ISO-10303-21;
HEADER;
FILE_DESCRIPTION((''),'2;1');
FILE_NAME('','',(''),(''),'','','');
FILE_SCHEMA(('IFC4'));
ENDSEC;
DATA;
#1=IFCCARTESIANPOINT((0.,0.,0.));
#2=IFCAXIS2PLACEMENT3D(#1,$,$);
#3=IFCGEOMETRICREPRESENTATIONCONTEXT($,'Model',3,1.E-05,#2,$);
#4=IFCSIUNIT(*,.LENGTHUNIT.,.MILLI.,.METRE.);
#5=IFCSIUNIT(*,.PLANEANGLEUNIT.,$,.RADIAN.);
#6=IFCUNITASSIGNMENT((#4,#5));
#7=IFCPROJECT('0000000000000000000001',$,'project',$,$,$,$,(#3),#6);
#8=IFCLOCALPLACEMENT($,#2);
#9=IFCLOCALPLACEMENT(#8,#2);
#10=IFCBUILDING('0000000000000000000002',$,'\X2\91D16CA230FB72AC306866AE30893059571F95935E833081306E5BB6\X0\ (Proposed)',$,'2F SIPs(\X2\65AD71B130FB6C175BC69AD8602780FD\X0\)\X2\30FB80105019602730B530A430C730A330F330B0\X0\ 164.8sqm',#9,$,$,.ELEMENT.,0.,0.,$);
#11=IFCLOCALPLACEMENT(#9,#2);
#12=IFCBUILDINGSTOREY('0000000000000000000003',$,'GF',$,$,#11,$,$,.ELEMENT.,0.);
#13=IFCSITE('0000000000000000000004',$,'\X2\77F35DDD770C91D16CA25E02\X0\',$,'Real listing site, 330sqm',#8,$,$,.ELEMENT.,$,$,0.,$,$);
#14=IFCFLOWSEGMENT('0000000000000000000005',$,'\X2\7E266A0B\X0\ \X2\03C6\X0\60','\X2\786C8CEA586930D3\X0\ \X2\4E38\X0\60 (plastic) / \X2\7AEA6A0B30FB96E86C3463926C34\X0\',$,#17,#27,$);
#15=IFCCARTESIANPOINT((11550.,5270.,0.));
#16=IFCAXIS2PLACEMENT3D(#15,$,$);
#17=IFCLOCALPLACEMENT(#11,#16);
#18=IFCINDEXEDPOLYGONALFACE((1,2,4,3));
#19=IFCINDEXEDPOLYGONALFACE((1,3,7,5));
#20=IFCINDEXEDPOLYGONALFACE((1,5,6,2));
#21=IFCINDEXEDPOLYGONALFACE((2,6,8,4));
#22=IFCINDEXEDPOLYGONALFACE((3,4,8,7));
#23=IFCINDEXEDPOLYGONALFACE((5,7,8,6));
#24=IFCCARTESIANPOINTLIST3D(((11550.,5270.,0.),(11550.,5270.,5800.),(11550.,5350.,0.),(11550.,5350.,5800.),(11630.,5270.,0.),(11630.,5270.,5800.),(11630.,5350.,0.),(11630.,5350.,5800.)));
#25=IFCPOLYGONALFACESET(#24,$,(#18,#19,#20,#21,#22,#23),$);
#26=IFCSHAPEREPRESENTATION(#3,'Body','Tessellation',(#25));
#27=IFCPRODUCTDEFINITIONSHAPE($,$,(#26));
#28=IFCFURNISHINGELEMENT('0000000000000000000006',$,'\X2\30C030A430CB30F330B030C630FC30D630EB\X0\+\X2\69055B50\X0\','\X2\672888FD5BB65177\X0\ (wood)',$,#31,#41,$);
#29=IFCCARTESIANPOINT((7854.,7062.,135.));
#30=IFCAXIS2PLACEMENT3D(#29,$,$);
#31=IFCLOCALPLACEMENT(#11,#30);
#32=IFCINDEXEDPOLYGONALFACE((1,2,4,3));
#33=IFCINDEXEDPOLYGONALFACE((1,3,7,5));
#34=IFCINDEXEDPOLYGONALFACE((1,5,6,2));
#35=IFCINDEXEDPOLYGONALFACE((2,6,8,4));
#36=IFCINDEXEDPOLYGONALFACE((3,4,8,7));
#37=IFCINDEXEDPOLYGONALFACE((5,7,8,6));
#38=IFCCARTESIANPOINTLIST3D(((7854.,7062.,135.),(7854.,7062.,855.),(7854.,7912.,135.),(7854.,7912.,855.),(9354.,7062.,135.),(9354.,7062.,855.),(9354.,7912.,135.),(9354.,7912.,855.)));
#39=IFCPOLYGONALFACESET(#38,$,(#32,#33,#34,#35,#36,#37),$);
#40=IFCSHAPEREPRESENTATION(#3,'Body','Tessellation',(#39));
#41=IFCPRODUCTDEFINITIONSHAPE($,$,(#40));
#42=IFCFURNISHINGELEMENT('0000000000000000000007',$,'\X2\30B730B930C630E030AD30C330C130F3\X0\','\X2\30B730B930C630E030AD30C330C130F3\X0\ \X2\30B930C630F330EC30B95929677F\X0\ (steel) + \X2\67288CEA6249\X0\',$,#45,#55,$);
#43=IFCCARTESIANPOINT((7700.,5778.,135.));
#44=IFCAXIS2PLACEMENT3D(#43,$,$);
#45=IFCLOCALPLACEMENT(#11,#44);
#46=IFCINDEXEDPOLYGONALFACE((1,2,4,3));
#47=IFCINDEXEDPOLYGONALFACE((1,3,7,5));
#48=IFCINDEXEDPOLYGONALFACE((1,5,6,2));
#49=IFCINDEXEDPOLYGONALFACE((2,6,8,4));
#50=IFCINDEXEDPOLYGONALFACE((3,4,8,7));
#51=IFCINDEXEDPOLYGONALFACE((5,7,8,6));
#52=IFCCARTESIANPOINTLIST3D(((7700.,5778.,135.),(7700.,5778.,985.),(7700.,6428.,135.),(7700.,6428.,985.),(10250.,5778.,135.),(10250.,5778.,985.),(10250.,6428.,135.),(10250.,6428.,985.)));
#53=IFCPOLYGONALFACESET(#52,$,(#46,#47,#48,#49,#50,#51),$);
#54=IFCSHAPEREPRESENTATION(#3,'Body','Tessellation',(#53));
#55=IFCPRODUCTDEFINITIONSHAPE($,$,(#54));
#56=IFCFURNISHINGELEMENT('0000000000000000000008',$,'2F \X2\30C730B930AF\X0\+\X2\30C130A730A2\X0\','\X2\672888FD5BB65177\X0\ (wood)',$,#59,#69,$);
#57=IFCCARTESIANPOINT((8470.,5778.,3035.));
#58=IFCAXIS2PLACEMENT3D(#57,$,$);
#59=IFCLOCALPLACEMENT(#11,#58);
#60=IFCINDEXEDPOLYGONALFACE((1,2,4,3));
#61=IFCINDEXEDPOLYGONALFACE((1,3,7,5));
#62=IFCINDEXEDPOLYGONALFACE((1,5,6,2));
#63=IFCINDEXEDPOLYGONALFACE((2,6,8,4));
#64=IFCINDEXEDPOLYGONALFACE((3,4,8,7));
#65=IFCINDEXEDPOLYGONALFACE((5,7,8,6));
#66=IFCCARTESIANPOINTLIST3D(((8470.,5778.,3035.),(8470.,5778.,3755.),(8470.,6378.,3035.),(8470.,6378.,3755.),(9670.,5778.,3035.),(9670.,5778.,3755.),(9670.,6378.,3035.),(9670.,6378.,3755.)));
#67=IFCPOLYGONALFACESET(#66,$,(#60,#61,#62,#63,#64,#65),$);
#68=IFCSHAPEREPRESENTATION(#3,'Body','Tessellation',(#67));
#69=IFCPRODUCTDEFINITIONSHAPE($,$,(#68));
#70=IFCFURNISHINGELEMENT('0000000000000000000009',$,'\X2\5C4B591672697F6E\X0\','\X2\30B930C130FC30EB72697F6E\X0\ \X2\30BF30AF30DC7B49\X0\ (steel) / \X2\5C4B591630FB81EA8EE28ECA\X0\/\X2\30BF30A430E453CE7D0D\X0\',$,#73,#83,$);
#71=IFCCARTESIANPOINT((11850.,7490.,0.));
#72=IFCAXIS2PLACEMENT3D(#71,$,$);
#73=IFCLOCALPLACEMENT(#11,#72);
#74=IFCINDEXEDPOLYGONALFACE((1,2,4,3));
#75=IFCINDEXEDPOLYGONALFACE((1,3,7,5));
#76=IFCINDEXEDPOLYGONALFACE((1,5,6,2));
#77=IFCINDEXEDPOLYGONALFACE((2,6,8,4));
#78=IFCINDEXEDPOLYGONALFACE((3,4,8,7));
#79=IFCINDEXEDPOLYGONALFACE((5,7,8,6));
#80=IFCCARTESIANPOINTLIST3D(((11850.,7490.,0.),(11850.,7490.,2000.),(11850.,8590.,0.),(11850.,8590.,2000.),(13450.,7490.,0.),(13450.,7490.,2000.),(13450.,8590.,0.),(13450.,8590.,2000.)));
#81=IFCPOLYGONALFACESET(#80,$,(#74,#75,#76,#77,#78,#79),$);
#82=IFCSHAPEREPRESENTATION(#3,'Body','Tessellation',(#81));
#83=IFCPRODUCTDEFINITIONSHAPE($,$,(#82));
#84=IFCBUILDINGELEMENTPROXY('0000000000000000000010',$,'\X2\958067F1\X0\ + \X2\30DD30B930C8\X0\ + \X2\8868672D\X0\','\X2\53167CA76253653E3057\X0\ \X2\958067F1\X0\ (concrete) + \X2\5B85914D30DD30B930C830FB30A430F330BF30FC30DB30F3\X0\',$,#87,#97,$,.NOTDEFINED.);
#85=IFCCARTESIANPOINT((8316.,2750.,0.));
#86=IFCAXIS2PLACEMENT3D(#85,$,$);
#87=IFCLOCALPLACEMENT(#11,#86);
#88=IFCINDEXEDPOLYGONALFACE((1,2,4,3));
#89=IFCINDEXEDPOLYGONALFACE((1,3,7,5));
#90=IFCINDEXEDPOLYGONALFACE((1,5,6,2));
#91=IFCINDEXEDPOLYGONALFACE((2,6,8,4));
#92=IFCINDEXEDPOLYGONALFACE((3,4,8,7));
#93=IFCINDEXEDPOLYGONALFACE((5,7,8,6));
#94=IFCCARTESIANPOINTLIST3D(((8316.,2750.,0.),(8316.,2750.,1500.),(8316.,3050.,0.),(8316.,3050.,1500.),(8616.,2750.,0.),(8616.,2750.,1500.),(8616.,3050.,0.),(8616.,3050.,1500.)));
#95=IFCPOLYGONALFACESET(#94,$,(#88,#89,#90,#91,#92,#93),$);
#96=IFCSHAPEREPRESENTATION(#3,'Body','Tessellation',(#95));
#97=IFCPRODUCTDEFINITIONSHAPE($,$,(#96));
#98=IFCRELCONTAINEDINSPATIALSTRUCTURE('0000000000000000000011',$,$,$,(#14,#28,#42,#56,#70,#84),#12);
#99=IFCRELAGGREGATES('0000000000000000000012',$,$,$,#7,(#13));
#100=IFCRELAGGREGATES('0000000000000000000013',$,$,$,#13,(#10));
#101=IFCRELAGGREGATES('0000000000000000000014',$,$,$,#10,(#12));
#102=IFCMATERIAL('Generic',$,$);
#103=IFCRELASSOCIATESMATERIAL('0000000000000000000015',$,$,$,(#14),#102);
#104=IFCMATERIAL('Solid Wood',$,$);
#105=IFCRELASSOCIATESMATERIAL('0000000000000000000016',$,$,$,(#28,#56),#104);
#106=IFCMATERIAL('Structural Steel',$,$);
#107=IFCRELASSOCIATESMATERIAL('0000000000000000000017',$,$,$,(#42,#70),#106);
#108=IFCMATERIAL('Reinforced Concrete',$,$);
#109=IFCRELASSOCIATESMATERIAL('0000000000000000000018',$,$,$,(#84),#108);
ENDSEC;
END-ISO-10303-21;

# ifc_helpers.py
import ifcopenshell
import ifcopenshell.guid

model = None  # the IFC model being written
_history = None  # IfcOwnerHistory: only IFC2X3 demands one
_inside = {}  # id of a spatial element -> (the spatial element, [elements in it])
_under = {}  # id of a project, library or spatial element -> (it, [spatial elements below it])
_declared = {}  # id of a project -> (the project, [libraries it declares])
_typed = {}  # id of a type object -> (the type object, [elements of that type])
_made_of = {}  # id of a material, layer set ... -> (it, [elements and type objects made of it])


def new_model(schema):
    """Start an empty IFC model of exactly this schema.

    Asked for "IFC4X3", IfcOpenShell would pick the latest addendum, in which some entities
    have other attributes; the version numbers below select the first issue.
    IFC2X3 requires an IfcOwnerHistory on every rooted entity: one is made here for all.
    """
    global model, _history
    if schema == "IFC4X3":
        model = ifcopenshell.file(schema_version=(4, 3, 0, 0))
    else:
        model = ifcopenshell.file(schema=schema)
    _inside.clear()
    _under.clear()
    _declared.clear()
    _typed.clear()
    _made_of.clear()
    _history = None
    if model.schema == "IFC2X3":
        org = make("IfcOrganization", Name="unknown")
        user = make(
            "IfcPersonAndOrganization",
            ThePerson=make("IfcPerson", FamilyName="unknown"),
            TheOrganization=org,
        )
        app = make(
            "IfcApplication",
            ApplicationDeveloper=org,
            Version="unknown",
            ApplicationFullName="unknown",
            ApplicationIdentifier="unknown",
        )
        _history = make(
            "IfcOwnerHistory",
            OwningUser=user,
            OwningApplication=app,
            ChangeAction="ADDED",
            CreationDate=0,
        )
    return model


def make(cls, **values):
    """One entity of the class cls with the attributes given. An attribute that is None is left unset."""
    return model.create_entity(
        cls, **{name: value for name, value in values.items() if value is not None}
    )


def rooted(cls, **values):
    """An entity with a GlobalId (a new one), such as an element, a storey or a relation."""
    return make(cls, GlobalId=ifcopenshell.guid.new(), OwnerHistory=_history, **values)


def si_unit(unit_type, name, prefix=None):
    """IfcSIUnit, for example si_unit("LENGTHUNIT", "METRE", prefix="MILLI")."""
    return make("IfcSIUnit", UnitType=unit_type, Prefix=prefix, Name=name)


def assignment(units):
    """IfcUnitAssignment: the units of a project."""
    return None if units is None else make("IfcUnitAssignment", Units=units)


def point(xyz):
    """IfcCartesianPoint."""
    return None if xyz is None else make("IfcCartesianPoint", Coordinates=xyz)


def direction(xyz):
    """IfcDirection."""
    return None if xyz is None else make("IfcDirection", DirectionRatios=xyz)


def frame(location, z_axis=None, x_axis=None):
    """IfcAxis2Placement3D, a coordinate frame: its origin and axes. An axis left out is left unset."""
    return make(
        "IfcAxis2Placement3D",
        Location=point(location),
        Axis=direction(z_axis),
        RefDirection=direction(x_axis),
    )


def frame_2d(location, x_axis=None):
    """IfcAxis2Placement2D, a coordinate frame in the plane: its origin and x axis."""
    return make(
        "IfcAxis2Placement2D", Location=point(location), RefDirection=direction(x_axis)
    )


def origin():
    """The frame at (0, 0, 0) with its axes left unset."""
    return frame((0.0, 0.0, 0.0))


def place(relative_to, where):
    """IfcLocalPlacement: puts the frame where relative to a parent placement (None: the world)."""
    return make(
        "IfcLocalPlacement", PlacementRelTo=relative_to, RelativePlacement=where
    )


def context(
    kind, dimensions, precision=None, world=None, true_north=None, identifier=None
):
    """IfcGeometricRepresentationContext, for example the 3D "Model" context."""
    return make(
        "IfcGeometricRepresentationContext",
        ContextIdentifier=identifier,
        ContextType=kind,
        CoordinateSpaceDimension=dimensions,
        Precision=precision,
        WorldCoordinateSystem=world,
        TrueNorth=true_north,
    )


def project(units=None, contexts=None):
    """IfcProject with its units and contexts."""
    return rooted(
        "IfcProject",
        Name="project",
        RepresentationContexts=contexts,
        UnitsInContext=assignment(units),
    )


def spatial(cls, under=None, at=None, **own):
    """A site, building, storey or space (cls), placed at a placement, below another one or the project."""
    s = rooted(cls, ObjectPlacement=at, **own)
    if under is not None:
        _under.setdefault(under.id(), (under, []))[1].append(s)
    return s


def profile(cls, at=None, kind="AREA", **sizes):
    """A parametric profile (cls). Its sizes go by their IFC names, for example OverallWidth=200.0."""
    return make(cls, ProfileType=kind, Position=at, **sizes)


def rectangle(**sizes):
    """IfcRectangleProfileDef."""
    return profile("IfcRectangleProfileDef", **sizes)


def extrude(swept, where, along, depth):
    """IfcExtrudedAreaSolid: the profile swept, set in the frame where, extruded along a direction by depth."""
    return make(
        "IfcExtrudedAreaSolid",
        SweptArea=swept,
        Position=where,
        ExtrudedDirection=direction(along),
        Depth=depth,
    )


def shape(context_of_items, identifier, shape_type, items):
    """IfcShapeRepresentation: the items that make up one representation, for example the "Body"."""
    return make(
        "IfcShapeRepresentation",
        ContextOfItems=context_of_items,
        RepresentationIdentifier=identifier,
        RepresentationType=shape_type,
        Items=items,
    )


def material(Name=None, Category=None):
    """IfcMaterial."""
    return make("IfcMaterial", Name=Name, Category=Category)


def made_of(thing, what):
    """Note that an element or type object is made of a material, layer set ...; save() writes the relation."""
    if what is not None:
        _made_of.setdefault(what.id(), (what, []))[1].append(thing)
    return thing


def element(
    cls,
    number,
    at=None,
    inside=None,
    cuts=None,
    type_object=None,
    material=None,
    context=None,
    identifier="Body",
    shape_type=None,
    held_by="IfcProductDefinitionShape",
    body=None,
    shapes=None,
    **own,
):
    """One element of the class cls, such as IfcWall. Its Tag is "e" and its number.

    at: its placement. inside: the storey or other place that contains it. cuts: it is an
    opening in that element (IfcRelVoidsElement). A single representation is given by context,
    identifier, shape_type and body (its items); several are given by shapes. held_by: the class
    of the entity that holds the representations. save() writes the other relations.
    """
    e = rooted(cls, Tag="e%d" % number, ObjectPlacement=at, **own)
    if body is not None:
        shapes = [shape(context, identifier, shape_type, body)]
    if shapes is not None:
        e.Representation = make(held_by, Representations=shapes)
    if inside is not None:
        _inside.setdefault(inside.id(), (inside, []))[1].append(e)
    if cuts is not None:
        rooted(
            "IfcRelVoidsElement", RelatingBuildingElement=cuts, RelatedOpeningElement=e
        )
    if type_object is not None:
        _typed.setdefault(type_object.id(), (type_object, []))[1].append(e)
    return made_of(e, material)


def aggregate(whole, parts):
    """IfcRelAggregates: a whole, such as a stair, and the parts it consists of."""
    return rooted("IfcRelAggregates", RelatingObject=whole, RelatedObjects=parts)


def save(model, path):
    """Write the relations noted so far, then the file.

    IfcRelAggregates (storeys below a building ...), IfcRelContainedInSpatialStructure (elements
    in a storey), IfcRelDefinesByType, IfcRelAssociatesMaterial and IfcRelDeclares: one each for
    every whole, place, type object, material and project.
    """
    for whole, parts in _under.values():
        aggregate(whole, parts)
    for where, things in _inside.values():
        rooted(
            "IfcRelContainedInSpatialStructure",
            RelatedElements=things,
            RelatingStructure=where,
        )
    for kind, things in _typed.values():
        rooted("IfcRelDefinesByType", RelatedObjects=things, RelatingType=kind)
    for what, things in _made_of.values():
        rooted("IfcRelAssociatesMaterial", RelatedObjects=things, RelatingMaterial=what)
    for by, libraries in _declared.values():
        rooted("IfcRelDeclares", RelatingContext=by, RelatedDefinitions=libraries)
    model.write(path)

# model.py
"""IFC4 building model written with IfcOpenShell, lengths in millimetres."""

from ifc_helpers import new_model, si_unit, frame, frame_2d, origin, place, context, project, spatial, rectangle, extrude, material, element, save


model = new_model("IFC4")

# Units and contexts
model_context = context("Model", 3, precision=1e-05, world=origin())
ifc_project = project(units=[si_unit("LENGTHUNIT", "METRE", prefix="MILLI"), si_unit("PLANEANGLEUNIT", "RADIAN")], contexts=[model_context])

# Site, building, storey
site_placement = place(None, origin())
site = spatial("IfcSite", under=ifc_project, at=site_placement, Name="石川県金沢市", ObjectType="Real listing site, 330sqm", CompositionType="ELEMENT", RefElevation=0.0)
building_placement = place(site_placement, origin())
building = spatial("IfcBuilding", under=site, at=building_placement, Name="金沢・犬と暮らす土間広めの家 (Proposed)", ObjectType="2F SIPs(断熱・気密高性能)・耐候性サイディング 164.8sqm", CompositionType="ELEMENT", ElevationOfRefHeight=0.0, ElevationOfTerrain=0.0)
storey_placement = place(building_placement, origin())
storey = spatial("IfcBuildingStorey", under=building, at=storey_placement, Name="GF", CompositionType="ELEMENT", Elevation=0.0)

# Shared definitions
ifc_material_1 = material(Name="Solid Wood")

# Shared definitions
ifc_material_2 = material(Name="Reinforced Concrete")

# Shared definitions
ifc_material_3 = material(Name="Structural Steel")

# Shared definitions
ifc_material_4 = material(Name="Generic")

# Flow segment
flow_segment_placement = place(storey_placement, frame((11550.0, 5270.0, 0.0)))
element("IfcFlowSegment", 1, at=flow_segment_placement, inside=storey, material=ifc_material_4, Name="縦樋 φ60", Description="硬質塩ビ 丸60 (plastic) / 竪樋・雨水排水", context=model_context, shape_type="SweptSolid", body=[
    extrude(rectangle(XDim=80.0, YDim=80.0, at=frame_2d((40.0, 40.0))), frame((11550.0, 5270.0, 0.0)), (0.0, 0.0, 1.0), 5800.0),
])

# Furnishing elements
furnishing_1_placement = place(storey_placement, frame((7854.0, 7062.0, 135.0)))
element("IfcFurnishingElement", 2, at=furnishing_1_placement, inside=storey, material=ifc_material_1, Name="ダイニングテーブル+椅子", Description="木製家具 (wood)", context=model_context, shape_type="SweptSolid", body=[
    extrude(rectangle(XDim=1500.0, YDim=850.0, at=frame_2d((750.0, 425.0))), frame((7854.0, 7062.0, 135.0)), (0.0, 0.0, 1.0), 720.0),
])
furnishing_2_placement = place(storey_placement, frame((7700.0, 5778.0, 135.0)))
element("IfcFurnishingElement", 3, at=furnishing_2_placement, inside=storey, material=ifc_material_3, Name="システムキッチン", Description="システムキッチン ステンレス天板 (steel) + 木質扉", context=model_context, shape_type="SweptSolid", body=[
    extrude(rectangle(XDim=2550.0, YDim=650.0, at=frame_2d((1275.0, 325.0))), frame((7700.0, 5778.0, 135.0)), (0.0, 0.0, 1.0), 850.0),
])
furnishing_3_placement = place(storey_placement, frame((8470.0, 5778.0, 3035.0)))
element("IfcFurnishingElement", 4, at=furnishing_3_placement, inside=storey, material=ifc_material_1, Name="2F デスク+チェア", Description="木製家具 (wood)", context=model_context, shape_type="SweptSolid", body=[
    extrude(rectangle(XDim=1200.0, YDim=600.0, at=frame_2d((600.0, 300.0))), frame((8470.0, 5778.0, 3035.0)), (0.0, 0.0, 1.0), 720.0),
])
furnishing_4_placement = place(storey_placement, frame((11850.0, 7490.0, 0.0)))
element("IfcFurnishingElement", 5, at=furnishing_4_placement, inside=storey, material=ifc_material_3, Name="屋外物置", Description="スチール物置 タクボ等 (steel) / 屋外・自転車/タイヤ収納", context=model_context, shape_type="SweptSolid", body=[
    extrude(rectangle(XDim=1600.0, YDim=1100.0, at=frame_2d((800.0, 550.0))), frame((11850.0, 7490.0, 0.0)), (0.0, 0.0, 1.0), 2000.0),
])

# Building element proxy
proxy_placement = place(storey_placement, frame((8316.0, 2750.0, 0.0)))
element("IfcBuildingElementProxy", 6, at=proxy_placement, inside=storey, material=ifc_material_2, Name="門柱 + ポスト + 表札", Description="化粧打放し 門柱 (concrete) + 宅配ポスト・インターホン", PredefinedType="NOTDEFINED", context=model_context, shape_type="SweptSolid", body=[
    extrude(rectangle(XDim=300.0, YDim=300.0, at=frame_2d((150.0, 150.0))), frame((8316.0, 2750.0, 0.0)), (0.0, 0.0, 1.0), 1500.0),
])

save(model, "model.ifc")
